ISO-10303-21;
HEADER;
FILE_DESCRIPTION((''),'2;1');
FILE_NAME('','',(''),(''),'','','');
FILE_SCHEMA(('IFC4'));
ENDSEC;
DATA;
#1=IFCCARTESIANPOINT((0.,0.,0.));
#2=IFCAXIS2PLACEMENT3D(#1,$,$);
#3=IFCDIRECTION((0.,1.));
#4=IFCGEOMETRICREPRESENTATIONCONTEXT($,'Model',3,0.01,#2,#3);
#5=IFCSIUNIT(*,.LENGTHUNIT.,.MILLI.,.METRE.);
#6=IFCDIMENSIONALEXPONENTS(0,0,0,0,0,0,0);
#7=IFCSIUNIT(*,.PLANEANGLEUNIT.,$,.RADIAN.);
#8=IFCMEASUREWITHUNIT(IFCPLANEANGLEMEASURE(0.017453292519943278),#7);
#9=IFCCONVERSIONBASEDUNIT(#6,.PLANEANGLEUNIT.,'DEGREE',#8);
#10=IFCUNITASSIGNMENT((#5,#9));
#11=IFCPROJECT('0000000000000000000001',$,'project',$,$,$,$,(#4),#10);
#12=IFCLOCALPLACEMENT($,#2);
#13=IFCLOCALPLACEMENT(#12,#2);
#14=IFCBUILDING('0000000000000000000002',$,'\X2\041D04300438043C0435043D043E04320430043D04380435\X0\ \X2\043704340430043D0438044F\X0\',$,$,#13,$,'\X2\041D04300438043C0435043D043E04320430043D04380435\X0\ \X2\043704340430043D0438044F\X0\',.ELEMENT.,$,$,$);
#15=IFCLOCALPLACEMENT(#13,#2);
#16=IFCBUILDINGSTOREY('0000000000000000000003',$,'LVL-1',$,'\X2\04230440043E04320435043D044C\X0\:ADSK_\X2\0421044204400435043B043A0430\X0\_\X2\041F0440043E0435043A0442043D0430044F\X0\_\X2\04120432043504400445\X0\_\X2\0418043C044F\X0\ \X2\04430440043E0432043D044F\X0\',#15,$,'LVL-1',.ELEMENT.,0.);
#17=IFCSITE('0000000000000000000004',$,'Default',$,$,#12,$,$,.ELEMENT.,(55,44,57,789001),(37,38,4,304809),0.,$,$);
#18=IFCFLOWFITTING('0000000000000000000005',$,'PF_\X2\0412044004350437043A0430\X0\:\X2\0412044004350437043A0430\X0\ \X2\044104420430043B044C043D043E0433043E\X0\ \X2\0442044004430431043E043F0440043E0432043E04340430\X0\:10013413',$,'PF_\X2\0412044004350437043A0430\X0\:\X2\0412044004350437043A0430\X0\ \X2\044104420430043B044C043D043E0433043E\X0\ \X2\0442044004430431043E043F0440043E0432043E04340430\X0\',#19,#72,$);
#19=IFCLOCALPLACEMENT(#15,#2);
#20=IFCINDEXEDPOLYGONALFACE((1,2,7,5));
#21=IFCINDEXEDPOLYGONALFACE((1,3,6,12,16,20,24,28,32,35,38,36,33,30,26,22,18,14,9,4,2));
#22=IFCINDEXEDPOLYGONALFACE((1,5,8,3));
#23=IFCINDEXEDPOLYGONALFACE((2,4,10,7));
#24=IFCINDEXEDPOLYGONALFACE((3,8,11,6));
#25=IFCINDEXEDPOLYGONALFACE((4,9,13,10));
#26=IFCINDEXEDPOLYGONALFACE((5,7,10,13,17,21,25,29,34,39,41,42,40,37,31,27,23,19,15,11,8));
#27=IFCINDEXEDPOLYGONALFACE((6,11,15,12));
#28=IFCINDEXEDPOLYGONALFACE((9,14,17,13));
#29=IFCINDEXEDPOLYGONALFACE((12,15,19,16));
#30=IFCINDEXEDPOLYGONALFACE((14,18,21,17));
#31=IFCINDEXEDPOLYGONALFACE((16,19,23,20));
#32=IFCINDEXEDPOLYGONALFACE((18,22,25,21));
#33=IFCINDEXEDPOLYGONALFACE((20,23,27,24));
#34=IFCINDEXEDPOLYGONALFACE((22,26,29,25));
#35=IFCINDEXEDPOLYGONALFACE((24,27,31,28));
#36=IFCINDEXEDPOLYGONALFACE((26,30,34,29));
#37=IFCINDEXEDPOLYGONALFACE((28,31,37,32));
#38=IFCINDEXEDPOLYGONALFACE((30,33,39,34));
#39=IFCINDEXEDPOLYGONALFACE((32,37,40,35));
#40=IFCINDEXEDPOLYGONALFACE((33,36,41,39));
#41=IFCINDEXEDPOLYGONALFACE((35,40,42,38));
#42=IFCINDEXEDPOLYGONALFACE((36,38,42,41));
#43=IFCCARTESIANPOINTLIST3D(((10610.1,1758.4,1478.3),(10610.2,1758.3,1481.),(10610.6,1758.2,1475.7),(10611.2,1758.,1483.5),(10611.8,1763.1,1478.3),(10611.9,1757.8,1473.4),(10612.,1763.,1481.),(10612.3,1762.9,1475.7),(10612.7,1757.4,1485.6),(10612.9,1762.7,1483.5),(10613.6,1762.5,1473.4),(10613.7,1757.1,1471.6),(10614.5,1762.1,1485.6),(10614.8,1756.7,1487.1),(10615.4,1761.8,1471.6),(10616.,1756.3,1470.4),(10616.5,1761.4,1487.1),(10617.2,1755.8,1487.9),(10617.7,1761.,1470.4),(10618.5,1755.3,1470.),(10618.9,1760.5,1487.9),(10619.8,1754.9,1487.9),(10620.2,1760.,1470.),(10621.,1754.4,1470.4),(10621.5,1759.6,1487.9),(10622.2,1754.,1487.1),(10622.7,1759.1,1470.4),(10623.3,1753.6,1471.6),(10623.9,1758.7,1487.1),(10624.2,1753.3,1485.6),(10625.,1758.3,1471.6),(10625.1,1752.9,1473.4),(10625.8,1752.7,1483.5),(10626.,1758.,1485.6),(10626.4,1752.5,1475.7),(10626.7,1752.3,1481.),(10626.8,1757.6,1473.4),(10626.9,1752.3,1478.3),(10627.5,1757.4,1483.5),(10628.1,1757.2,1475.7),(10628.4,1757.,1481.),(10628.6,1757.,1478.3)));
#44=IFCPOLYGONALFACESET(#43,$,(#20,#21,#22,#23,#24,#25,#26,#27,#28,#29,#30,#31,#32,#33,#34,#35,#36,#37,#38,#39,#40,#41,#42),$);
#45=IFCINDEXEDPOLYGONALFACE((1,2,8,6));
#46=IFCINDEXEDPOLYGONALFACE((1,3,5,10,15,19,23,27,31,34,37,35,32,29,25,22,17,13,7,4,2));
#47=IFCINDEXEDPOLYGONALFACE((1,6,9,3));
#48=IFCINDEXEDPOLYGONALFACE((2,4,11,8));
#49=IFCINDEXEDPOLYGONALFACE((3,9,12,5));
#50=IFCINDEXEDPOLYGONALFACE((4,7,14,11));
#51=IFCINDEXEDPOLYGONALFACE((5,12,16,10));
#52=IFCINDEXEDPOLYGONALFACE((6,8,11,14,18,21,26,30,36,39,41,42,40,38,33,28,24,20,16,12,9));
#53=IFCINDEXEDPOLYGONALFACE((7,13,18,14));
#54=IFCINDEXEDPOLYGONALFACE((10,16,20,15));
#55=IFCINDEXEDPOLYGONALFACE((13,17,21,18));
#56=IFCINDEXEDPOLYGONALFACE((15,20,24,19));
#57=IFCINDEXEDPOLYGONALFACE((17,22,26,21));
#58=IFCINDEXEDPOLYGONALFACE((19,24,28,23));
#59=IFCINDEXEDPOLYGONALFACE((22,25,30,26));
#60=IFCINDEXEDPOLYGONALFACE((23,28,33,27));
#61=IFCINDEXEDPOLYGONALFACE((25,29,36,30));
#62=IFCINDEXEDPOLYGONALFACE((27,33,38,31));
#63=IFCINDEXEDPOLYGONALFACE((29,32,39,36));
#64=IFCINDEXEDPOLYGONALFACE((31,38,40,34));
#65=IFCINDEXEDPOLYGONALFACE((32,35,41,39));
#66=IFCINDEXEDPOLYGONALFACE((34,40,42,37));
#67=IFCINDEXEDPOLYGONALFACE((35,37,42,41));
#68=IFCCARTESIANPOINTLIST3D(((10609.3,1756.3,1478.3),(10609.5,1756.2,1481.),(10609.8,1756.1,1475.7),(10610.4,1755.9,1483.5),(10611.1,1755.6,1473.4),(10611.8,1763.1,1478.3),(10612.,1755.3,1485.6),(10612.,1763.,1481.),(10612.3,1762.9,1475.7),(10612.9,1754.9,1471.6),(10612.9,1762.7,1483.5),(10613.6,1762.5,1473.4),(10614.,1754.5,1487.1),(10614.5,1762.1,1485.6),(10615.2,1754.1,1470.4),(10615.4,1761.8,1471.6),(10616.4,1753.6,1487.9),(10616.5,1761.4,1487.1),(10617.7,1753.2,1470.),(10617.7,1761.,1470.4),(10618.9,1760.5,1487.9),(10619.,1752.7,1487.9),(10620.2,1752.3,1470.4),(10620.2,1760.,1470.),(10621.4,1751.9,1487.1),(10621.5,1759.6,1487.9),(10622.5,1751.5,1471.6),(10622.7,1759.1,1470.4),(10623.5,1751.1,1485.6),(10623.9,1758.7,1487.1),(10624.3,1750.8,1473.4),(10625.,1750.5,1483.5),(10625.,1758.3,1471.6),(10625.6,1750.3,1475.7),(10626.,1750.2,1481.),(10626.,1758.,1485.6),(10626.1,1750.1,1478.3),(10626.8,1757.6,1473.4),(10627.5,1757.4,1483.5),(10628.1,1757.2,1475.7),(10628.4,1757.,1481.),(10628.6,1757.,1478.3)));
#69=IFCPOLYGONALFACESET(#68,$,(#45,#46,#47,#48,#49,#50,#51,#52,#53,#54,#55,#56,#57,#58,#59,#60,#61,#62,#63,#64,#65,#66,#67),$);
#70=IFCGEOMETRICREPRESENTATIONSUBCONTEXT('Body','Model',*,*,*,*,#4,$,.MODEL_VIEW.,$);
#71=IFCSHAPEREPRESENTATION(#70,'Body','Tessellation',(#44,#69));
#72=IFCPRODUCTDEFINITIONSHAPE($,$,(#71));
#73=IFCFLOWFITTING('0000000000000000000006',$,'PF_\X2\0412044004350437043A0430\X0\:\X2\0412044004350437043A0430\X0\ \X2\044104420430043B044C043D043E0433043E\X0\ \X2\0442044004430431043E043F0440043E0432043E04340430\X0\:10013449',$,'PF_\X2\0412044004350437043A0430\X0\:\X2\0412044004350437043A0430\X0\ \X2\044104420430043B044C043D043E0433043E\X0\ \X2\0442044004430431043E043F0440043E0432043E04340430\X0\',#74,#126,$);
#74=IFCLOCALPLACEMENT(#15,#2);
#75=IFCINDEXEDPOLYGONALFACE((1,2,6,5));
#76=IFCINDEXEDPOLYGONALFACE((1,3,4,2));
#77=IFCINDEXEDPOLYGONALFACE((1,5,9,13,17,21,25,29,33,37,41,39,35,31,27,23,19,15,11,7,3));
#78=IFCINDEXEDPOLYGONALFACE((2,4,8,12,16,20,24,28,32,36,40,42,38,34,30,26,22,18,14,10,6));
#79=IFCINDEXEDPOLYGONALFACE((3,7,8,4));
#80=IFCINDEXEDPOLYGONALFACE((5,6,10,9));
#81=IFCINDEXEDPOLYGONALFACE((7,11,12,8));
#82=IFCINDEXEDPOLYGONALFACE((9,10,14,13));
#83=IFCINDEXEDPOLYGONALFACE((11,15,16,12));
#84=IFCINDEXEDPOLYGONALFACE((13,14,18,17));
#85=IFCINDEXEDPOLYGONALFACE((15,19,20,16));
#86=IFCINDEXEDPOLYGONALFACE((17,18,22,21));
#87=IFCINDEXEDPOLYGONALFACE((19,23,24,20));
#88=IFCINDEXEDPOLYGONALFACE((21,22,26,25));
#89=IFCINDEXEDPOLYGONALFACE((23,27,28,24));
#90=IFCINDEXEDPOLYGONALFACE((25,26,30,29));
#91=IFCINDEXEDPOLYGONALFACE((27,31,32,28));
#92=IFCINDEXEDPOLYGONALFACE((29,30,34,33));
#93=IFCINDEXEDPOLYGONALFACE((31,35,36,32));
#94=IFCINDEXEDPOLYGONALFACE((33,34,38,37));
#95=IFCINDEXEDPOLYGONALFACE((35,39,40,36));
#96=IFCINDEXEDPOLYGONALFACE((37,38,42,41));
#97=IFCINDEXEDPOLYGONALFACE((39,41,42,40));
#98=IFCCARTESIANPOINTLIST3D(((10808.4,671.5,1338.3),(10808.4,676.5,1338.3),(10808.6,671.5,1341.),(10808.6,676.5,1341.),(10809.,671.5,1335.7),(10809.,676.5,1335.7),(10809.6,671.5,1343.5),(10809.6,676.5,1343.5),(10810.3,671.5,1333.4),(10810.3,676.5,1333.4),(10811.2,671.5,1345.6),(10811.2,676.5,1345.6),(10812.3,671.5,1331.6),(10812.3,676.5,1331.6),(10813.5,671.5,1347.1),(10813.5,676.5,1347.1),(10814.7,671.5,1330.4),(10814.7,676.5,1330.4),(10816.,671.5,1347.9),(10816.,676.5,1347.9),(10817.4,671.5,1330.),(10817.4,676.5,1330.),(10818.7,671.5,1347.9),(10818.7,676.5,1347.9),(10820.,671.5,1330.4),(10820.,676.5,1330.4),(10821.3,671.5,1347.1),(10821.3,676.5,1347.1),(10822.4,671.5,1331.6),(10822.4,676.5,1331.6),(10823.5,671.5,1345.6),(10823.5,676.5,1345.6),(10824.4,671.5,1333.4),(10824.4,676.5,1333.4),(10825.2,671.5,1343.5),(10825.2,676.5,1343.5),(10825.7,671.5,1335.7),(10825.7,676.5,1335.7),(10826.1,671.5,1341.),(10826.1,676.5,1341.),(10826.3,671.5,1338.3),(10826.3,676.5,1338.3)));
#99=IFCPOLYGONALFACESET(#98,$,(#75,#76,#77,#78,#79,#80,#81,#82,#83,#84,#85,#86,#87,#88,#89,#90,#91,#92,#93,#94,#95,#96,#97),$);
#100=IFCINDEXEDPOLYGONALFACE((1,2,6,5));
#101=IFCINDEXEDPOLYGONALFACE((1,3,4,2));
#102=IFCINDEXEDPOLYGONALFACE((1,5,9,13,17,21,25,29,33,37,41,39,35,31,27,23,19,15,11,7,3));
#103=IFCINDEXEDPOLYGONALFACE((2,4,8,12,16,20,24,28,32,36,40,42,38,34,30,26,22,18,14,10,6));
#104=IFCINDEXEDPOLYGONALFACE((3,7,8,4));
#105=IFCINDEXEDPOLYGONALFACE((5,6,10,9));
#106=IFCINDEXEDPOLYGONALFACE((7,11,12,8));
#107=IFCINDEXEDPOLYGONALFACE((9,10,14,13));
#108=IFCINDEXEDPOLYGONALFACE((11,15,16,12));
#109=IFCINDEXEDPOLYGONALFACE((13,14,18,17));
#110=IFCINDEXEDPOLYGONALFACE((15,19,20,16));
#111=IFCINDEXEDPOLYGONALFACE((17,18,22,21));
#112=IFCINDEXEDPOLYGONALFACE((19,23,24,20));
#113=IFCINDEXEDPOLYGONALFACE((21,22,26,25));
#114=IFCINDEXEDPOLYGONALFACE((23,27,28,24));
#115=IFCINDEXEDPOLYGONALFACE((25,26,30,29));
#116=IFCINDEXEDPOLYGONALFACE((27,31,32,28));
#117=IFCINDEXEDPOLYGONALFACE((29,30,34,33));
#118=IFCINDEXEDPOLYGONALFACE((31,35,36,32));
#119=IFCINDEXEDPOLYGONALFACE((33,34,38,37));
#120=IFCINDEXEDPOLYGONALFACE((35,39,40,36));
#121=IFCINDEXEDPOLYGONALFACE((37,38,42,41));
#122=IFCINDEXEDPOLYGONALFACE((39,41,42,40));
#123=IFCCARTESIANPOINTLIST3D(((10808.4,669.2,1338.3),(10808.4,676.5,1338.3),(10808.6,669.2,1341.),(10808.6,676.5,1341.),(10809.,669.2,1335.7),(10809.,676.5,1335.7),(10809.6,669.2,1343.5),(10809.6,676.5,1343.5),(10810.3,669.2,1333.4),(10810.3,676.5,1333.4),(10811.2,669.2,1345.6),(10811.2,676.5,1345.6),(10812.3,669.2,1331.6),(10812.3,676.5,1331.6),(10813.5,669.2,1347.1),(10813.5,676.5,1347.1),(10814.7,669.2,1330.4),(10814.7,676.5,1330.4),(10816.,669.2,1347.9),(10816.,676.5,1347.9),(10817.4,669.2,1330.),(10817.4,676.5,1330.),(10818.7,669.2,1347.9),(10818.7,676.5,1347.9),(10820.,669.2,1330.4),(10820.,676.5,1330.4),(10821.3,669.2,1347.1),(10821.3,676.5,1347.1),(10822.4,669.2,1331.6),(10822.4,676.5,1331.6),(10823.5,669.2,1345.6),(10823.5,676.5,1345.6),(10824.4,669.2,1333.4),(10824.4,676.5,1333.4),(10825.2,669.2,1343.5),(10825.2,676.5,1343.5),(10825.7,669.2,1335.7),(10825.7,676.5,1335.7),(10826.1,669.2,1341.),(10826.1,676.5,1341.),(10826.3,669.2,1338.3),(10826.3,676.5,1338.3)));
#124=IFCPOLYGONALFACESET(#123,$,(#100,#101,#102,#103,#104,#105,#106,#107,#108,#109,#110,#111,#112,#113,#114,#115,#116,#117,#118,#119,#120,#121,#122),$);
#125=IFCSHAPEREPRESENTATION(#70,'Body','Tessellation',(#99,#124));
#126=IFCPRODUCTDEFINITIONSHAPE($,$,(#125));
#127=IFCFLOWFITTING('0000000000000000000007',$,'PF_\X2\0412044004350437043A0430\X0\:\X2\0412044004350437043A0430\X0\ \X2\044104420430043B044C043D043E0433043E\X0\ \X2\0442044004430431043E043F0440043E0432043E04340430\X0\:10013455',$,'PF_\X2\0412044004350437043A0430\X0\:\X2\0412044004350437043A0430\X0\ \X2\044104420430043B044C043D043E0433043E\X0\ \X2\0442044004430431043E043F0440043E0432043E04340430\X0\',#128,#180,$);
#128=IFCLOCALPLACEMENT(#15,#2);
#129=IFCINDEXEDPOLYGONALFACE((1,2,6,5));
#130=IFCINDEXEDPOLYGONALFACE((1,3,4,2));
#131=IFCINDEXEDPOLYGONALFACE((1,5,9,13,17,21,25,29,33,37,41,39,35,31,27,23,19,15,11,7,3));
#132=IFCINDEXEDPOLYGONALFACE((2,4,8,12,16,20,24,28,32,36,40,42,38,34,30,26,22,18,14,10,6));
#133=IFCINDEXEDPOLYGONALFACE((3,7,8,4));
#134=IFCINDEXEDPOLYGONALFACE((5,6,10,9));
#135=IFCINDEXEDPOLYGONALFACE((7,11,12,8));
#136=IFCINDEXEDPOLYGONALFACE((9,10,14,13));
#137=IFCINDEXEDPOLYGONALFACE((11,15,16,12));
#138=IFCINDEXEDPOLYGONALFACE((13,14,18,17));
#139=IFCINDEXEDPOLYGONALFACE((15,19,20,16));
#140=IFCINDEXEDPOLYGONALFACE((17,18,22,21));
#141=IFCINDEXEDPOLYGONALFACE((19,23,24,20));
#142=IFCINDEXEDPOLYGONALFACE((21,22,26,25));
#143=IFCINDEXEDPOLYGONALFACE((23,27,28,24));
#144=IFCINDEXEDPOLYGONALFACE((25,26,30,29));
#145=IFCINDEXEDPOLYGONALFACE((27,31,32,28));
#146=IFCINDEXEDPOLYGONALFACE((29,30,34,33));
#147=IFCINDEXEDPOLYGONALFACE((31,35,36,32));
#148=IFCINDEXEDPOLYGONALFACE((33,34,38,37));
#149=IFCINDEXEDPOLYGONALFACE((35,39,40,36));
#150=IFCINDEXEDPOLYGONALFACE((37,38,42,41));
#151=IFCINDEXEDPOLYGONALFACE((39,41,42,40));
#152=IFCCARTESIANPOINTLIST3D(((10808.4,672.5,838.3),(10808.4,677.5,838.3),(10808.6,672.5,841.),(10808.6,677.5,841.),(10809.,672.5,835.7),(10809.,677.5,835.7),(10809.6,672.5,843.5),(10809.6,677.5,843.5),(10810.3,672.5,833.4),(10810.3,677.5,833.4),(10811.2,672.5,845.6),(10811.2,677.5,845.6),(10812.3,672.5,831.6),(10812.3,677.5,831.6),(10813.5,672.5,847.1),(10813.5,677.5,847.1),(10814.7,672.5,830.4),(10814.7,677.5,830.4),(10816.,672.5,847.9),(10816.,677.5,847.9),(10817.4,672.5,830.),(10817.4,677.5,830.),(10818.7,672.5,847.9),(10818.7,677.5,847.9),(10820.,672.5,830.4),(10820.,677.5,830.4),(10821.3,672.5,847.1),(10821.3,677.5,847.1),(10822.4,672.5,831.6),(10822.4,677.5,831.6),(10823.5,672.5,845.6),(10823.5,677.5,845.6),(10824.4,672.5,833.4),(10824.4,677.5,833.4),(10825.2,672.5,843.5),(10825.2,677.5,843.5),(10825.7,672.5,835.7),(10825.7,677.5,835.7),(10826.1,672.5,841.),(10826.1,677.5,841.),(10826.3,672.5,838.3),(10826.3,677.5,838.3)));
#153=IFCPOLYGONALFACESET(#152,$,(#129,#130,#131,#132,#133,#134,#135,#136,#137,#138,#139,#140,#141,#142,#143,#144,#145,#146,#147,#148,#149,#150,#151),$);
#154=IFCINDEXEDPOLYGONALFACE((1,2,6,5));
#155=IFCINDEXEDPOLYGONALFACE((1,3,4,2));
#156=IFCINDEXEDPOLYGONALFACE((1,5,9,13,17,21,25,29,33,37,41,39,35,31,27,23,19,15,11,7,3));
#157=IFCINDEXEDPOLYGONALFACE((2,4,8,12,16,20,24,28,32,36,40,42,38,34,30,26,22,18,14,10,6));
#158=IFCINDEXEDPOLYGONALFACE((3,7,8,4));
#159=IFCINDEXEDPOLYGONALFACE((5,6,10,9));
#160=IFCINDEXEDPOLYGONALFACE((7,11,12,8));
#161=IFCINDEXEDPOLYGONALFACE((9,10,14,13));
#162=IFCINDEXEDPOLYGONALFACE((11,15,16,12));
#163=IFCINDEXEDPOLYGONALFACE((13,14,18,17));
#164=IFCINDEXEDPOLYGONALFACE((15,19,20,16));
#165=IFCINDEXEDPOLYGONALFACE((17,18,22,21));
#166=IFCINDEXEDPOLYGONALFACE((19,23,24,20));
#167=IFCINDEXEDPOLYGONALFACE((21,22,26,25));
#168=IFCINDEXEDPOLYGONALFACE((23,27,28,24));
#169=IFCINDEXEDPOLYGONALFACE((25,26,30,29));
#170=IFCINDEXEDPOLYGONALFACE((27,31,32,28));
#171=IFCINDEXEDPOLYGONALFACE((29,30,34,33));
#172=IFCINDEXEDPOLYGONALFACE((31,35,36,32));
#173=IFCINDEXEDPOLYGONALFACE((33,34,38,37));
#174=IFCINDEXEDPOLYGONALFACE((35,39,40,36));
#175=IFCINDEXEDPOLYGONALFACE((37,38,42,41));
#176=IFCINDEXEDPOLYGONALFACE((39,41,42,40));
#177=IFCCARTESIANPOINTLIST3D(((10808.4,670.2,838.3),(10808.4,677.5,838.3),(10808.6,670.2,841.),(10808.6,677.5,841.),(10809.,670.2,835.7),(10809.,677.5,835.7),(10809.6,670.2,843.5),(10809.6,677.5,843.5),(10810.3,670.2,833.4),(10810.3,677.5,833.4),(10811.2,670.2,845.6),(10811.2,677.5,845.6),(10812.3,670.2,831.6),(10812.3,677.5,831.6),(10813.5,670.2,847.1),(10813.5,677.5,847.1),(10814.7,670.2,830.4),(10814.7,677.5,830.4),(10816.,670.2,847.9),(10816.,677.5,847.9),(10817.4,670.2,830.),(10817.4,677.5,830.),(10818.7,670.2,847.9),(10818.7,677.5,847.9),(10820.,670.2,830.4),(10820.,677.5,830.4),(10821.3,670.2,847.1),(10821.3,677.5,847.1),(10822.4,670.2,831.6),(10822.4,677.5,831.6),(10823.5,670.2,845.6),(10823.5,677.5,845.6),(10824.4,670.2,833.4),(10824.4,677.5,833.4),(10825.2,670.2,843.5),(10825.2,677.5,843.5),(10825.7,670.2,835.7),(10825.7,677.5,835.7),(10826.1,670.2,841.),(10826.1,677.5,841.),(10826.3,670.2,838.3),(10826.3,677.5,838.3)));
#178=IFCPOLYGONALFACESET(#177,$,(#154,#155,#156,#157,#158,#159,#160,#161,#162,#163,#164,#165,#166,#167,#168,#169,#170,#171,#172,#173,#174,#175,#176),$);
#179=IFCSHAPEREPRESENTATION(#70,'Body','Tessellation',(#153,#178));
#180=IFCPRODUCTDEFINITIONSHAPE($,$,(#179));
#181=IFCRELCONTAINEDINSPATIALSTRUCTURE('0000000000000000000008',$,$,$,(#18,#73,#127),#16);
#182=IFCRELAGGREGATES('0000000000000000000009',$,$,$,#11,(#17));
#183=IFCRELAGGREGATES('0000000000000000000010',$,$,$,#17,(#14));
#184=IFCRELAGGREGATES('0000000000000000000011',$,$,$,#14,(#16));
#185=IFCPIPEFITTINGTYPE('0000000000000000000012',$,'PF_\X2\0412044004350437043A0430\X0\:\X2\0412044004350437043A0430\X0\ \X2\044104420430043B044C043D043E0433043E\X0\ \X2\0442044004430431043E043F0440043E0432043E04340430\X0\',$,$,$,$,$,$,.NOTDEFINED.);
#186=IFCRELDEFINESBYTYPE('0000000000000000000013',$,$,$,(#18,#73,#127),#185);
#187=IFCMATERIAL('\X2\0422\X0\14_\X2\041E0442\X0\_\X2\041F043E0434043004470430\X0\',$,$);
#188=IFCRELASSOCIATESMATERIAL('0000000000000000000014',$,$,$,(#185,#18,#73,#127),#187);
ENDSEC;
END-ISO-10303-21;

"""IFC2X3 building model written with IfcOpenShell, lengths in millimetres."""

from ifc_helpers import new_model, entity, si_unit, converted_unit, direction, frame, frame_2d, origin, place, context, subcontext, project, spatial, circle, extrude, source, transform, mapped, material, type_object, type_shapes, element, save


model = new_model("IFC2X3")

# Units and contexts
model_context = context("Model", 3, precision=0.01, world=origin(), true_north=direction((0.0, 1.0)))
body_context = subcontext(model_context, "Body", "Model", "MODEL_VIEW")
ifc_project = project(units=[si_unit("LENGTHUNIT", "METRE", prefix="MILLI"), converted_unit("PLANEANGLEUNIT", "DEGREE", entity("IfcPlaneAngleMeasure", 0.017453292519943278), si_unit("PLANEANGLEUNIT", "RADIAN"), dimensions=[0, 0, 0, 0, 0, 0, 0])], contexts=[model_context])

# Site, building, storey
site_placement = place(None, origin())
site = spatial("IfcSite", under=ifc_project, at=site_placement, Name="Default", CompositionType="ELEMENT", RefLatitude=(55, 44, 57, 789001), RefLongitude=(37, 38, 4, 304809), RefElevation=0.0)
building_placement = place(site_placement, origin())
building = spatial("IfcBuilding", under=site, at=building_placement, Name="Наименование здания", LongName="Наименование здания", CompositionType="ELEMENT")
storey_placement = place(building_placement, origin())
storey = spatial("IfcBuildingStorey", under=building, at=storey_placement, Name="LVL-1", ObjectType="Уровень:ADSK_Стрелка_Проектная_Вверх_Имя уровня", LongName="LVL-1", CompositionType="ELEMENT", Elevation=0.0)

# Flow fittings
ifc_material_1 = material(Name="Т14_От_Подача")
pipe_fitting_type_1 = type_object("IfcPipeFittingType", Name="PF_Врезка:Врезка стального трубопровода", PredefinedType="NOTDEFINED", material=ifc_material_1)
shared_shape_1 = source(origin(), body_context, "Body", "SweptSolid", [
    extrude(circle(Radius=9.0, at=frame_2d((0.0, 0.0), x_axis=(1.0, 0.0))), frame((-5.0, 0.0, 0.0), z_axis=(1.0, 0.0, 0.0), x_axis=(0.0, -1.0, 0.0)), (0.0, 0.0, 1.0), 5.0),
    extrude(circle(Radius=9.0, at=frame_2d((0.0, 0.0), x_axis=(1.0, 0.0))), frame((-7.3, 0.0, 0.0), z_axis=(1.0, 0.0, 0.0), x_axis=(0.0, -1.0, 0.0)), (0.0, 0.0, 1.0), 7.3),
])
type_shapes(pipe_fitting_type_1, [shared_shape_1])
for number, where, z_axis, x_axis, name in (
    (1, (10620.2, 1760.0, 1479.0), (0.939693, -0.34202, 0.0), (0.34202, 0.939693, 0.0), "PF_Врезка:Врезка стального трубопровода:10013413"),
    (2, (10817.4, 676.5, 1339.0), (1.0, 0.0, 0.0), (0.0, 1.0, 0.0), "PF_Врезка:Врезка стального трубопровода:10013449"),
    (3, (10817.4, 677.5, 839.0), (1.0, 0.0, 0.0), (0.0, 1.0, 0.0), "PF_Врезка:Врезка стального трубопровода:10013455"),
):
    element("IfcFlowFitting", number, at=place(storey_placement, frame(where, z_axis=z_axis, x_axis=x_axis)), inside=storey, type_object=pipe_fitting_type_1, material=ifc_material_1, Name=name, ObjectType="PF_Врезка:Врезка стального трубопровода", context=body_context, shape_type="MappedRepresentation", body=[
        mapped(shared_shape_1, transform((0.0, 0.0, 0.0), scale=1.0)),
    ])

save(model, "model.ifc")
